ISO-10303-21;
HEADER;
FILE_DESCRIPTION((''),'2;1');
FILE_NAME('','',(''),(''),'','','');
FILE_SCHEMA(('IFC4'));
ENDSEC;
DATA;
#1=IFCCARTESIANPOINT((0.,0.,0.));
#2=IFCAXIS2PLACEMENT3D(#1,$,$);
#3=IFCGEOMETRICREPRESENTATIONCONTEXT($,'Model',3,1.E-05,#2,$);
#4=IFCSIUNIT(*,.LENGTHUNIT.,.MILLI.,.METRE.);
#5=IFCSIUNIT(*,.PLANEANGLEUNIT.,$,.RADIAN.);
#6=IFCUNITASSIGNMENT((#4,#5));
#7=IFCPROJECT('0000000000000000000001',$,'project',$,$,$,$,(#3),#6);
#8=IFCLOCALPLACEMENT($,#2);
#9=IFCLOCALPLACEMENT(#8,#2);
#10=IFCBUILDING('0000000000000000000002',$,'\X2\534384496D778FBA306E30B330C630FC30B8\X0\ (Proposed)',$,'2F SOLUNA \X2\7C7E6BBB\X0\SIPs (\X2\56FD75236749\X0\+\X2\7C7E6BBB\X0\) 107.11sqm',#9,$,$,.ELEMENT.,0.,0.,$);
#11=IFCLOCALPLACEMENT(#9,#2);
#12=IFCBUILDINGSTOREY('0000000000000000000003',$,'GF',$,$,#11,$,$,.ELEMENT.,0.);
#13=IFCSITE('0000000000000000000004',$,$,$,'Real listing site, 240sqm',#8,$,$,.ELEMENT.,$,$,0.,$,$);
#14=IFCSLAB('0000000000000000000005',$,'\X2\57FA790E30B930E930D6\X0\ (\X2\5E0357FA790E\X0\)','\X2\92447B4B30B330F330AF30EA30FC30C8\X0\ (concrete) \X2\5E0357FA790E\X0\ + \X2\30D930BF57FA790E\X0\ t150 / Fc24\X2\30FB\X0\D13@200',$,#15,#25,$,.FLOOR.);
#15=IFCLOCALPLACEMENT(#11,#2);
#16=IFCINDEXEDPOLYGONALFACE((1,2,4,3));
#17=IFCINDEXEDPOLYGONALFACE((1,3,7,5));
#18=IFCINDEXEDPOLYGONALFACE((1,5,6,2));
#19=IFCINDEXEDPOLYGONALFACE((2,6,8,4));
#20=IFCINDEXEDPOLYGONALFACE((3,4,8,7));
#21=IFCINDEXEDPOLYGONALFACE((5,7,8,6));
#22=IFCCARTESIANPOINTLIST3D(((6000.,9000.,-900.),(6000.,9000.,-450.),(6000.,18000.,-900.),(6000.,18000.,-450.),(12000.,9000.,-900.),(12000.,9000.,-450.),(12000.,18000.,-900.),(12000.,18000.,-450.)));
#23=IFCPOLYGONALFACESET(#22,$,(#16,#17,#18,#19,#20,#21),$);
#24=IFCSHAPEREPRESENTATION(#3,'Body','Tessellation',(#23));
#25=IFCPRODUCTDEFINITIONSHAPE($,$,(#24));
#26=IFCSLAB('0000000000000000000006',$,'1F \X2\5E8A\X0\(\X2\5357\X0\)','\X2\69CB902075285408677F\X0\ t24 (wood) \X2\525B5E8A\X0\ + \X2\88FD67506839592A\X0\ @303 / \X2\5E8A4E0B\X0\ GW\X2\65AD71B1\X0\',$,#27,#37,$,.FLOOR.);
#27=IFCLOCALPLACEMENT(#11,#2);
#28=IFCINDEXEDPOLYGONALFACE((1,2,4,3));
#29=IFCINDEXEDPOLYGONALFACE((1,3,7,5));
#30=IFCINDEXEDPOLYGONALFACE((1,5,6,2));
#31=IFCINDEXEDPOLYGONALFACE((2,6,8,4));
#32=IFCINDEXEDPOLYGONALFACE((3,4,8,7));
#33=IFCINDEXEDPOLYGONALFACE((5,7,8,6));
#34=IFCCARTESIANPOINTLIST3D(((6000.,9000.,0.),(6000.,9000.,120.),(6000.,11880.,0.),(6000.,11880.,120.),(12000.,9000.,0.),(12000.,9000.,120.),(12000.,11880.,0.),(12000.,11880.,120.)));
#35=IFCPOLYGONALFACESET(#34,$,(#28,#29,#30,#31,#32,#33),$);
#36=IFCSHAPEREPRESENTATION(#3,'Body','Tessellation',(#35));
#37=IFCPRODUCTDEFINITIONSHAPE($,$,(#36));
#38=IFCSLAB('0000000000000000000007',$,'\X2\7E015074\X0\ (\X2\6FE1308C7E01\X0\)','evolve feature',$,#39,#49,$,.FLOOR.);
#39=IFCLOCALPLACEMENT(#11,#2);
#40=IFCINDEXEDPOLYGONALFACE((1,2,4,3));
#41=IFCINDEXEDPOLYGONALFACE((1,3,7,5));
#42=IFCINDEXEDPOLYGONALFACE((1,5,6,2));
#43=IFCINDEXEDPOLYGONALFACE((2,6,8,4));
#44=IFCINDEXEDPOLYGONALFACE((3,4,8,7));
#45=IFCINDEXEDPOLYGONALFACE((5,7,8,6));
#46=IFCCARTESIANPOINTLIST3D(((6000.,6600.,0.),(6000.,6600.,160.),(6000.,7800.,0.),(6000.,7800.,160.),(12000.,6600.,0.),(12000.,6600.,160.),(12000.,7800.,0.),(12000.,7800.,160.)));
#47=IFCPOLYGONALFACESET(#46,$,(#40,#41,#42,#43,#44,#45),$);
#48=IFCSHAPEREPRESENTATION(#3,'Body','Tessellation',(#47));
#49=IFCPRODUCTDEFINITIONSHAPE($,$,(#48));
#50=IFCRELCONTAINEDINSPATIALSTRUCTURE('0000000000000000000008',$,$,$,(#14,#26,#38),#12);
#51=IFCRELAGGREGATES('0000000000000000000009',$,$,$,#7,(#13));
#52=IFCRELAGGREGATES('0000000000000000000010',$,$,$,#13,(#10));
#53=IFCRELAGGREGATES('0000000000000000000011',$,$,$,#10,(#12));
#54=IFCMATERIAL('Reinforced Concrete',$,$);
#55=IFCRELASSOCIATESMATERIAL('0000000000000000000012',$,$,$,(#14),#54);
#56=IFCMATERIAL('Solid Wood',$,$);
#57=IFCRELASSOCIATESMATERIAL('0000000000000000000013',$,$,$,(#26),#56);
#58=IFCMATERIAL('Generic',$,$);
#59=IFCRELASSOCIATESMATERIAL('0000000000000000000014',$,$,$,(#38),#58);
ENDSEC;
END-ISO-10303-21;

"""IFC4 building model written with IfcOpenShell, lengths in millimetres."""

from ifc_helpers import new_model, si_unit, frame, frame_2d, origin, place, context, project, spatial, rectangle, extrude, material, element, save


model = new_model("IFC4")

# Units and contexts
model_context = context("Model", 3, precision=1e-05, world=origin())
ifc_project = project(units=[si_unit("LENGTHUNIT", "METRE", prefix="MILLI"), si_unit("PLANEANGLEUNIT", "RADIAN")], contexts=[model_context])

# Site, building, storey
site_placement = place(None, origin())
site = spatial("IfcSite", under=ifc_project, at=site_placement, ObjectType="Real listing site, 240sqm", CompositionType="ELEMENT", RefElevation=0.0)
building_placement = place(site_placement, origin())
building = spatial("IfcBuilding", under=site, at=building_placement, Name="千葉海辺のコテージ (Proposed)", ObjectType="2F SOLUNA 籾殻SIPs (国産杉+籾殻) 107.11sqm", CompositionType="ELEMENT", ElevationOfRefHeight=0.0, ElevationOfTerrain=0.0)
storey_placement = place(building_placement, origin())
storey = spatial("IfcBuildingStorey", under=building, at=storey_placement, Name="GF", CompositionType="ELEMENT", Elevation=0.0)

# Slabs
ifc_material_1 = material(Name="Reinforced Concrete")
slab_1_placement = place(storey_placement, frame((3000.0, 4500.0, -450.0)))
element("IfcSlab", 1, at=slab_1_placement, inside=storey, material=ifc_material_1, Name="基礎スラブ (布基礎)", Description="鉄筋コンクリート (concrete) 布基礎 + ベタ基礎 t150 / Fc24・D13@200", PredefinedType="FLOOR", context=model_context, shape_type="SweptSolid", body=[
    extrude(rectangle(XDim=6000.0, YDim=9000.0, at=frame_2d((3000.0, 4500.0))), frame((3000.0, 4500.0, -450.0)), (0.0, 0.0, 1.0), 450.0),
])
ifc_material_2 = material(Name="Solid Wood")
slab_2_placement = place(storey_placement, frame((3000.0, 4500.0, 0.0)))
element("IfcSlab", 2, at=slab_2_placement, inside=storey, material=ifc_material_2, Name="1F 床(南)", Description="構造用合板 t24 (wood) 剛床 + 製材根太 @303 / 床下 GW断熱", PredefinedType="FLOOR", context=model_context, shape_type="SweptSolid", body=[
    extrude(rectangle(XDim=6000.0, YDim=2880.0, at=frame_2d((3000.0, 1440.0))), frame((3000.0, 4500.0, 0.0)), (0.0, 0.0, 1.0), 120.0),
])
ifc_material_3 = material(Name="Generic")
slab_3_placement = place(storey_placement, frame((3000.0, 3300.0, 0.0)))
element("IfcSlab", 3, at=slab_3_placement, inside=storey, material=ifc_material_3, Name="縁側 (濡れ縁)", Description="evolve feature", PredefinedType="FLOOR", context=model_context, shape_type="SweptSolid", body=[
    extrude(rectangle(XDim=6000.0, YDim=1200.0, at=frame_2d((3000.0, 600.0))), frame((3000.0, 3300.0, 0.0)), (0.0, 0.0, 1.0), 160.0),
])

save(model, "model.ifc")
